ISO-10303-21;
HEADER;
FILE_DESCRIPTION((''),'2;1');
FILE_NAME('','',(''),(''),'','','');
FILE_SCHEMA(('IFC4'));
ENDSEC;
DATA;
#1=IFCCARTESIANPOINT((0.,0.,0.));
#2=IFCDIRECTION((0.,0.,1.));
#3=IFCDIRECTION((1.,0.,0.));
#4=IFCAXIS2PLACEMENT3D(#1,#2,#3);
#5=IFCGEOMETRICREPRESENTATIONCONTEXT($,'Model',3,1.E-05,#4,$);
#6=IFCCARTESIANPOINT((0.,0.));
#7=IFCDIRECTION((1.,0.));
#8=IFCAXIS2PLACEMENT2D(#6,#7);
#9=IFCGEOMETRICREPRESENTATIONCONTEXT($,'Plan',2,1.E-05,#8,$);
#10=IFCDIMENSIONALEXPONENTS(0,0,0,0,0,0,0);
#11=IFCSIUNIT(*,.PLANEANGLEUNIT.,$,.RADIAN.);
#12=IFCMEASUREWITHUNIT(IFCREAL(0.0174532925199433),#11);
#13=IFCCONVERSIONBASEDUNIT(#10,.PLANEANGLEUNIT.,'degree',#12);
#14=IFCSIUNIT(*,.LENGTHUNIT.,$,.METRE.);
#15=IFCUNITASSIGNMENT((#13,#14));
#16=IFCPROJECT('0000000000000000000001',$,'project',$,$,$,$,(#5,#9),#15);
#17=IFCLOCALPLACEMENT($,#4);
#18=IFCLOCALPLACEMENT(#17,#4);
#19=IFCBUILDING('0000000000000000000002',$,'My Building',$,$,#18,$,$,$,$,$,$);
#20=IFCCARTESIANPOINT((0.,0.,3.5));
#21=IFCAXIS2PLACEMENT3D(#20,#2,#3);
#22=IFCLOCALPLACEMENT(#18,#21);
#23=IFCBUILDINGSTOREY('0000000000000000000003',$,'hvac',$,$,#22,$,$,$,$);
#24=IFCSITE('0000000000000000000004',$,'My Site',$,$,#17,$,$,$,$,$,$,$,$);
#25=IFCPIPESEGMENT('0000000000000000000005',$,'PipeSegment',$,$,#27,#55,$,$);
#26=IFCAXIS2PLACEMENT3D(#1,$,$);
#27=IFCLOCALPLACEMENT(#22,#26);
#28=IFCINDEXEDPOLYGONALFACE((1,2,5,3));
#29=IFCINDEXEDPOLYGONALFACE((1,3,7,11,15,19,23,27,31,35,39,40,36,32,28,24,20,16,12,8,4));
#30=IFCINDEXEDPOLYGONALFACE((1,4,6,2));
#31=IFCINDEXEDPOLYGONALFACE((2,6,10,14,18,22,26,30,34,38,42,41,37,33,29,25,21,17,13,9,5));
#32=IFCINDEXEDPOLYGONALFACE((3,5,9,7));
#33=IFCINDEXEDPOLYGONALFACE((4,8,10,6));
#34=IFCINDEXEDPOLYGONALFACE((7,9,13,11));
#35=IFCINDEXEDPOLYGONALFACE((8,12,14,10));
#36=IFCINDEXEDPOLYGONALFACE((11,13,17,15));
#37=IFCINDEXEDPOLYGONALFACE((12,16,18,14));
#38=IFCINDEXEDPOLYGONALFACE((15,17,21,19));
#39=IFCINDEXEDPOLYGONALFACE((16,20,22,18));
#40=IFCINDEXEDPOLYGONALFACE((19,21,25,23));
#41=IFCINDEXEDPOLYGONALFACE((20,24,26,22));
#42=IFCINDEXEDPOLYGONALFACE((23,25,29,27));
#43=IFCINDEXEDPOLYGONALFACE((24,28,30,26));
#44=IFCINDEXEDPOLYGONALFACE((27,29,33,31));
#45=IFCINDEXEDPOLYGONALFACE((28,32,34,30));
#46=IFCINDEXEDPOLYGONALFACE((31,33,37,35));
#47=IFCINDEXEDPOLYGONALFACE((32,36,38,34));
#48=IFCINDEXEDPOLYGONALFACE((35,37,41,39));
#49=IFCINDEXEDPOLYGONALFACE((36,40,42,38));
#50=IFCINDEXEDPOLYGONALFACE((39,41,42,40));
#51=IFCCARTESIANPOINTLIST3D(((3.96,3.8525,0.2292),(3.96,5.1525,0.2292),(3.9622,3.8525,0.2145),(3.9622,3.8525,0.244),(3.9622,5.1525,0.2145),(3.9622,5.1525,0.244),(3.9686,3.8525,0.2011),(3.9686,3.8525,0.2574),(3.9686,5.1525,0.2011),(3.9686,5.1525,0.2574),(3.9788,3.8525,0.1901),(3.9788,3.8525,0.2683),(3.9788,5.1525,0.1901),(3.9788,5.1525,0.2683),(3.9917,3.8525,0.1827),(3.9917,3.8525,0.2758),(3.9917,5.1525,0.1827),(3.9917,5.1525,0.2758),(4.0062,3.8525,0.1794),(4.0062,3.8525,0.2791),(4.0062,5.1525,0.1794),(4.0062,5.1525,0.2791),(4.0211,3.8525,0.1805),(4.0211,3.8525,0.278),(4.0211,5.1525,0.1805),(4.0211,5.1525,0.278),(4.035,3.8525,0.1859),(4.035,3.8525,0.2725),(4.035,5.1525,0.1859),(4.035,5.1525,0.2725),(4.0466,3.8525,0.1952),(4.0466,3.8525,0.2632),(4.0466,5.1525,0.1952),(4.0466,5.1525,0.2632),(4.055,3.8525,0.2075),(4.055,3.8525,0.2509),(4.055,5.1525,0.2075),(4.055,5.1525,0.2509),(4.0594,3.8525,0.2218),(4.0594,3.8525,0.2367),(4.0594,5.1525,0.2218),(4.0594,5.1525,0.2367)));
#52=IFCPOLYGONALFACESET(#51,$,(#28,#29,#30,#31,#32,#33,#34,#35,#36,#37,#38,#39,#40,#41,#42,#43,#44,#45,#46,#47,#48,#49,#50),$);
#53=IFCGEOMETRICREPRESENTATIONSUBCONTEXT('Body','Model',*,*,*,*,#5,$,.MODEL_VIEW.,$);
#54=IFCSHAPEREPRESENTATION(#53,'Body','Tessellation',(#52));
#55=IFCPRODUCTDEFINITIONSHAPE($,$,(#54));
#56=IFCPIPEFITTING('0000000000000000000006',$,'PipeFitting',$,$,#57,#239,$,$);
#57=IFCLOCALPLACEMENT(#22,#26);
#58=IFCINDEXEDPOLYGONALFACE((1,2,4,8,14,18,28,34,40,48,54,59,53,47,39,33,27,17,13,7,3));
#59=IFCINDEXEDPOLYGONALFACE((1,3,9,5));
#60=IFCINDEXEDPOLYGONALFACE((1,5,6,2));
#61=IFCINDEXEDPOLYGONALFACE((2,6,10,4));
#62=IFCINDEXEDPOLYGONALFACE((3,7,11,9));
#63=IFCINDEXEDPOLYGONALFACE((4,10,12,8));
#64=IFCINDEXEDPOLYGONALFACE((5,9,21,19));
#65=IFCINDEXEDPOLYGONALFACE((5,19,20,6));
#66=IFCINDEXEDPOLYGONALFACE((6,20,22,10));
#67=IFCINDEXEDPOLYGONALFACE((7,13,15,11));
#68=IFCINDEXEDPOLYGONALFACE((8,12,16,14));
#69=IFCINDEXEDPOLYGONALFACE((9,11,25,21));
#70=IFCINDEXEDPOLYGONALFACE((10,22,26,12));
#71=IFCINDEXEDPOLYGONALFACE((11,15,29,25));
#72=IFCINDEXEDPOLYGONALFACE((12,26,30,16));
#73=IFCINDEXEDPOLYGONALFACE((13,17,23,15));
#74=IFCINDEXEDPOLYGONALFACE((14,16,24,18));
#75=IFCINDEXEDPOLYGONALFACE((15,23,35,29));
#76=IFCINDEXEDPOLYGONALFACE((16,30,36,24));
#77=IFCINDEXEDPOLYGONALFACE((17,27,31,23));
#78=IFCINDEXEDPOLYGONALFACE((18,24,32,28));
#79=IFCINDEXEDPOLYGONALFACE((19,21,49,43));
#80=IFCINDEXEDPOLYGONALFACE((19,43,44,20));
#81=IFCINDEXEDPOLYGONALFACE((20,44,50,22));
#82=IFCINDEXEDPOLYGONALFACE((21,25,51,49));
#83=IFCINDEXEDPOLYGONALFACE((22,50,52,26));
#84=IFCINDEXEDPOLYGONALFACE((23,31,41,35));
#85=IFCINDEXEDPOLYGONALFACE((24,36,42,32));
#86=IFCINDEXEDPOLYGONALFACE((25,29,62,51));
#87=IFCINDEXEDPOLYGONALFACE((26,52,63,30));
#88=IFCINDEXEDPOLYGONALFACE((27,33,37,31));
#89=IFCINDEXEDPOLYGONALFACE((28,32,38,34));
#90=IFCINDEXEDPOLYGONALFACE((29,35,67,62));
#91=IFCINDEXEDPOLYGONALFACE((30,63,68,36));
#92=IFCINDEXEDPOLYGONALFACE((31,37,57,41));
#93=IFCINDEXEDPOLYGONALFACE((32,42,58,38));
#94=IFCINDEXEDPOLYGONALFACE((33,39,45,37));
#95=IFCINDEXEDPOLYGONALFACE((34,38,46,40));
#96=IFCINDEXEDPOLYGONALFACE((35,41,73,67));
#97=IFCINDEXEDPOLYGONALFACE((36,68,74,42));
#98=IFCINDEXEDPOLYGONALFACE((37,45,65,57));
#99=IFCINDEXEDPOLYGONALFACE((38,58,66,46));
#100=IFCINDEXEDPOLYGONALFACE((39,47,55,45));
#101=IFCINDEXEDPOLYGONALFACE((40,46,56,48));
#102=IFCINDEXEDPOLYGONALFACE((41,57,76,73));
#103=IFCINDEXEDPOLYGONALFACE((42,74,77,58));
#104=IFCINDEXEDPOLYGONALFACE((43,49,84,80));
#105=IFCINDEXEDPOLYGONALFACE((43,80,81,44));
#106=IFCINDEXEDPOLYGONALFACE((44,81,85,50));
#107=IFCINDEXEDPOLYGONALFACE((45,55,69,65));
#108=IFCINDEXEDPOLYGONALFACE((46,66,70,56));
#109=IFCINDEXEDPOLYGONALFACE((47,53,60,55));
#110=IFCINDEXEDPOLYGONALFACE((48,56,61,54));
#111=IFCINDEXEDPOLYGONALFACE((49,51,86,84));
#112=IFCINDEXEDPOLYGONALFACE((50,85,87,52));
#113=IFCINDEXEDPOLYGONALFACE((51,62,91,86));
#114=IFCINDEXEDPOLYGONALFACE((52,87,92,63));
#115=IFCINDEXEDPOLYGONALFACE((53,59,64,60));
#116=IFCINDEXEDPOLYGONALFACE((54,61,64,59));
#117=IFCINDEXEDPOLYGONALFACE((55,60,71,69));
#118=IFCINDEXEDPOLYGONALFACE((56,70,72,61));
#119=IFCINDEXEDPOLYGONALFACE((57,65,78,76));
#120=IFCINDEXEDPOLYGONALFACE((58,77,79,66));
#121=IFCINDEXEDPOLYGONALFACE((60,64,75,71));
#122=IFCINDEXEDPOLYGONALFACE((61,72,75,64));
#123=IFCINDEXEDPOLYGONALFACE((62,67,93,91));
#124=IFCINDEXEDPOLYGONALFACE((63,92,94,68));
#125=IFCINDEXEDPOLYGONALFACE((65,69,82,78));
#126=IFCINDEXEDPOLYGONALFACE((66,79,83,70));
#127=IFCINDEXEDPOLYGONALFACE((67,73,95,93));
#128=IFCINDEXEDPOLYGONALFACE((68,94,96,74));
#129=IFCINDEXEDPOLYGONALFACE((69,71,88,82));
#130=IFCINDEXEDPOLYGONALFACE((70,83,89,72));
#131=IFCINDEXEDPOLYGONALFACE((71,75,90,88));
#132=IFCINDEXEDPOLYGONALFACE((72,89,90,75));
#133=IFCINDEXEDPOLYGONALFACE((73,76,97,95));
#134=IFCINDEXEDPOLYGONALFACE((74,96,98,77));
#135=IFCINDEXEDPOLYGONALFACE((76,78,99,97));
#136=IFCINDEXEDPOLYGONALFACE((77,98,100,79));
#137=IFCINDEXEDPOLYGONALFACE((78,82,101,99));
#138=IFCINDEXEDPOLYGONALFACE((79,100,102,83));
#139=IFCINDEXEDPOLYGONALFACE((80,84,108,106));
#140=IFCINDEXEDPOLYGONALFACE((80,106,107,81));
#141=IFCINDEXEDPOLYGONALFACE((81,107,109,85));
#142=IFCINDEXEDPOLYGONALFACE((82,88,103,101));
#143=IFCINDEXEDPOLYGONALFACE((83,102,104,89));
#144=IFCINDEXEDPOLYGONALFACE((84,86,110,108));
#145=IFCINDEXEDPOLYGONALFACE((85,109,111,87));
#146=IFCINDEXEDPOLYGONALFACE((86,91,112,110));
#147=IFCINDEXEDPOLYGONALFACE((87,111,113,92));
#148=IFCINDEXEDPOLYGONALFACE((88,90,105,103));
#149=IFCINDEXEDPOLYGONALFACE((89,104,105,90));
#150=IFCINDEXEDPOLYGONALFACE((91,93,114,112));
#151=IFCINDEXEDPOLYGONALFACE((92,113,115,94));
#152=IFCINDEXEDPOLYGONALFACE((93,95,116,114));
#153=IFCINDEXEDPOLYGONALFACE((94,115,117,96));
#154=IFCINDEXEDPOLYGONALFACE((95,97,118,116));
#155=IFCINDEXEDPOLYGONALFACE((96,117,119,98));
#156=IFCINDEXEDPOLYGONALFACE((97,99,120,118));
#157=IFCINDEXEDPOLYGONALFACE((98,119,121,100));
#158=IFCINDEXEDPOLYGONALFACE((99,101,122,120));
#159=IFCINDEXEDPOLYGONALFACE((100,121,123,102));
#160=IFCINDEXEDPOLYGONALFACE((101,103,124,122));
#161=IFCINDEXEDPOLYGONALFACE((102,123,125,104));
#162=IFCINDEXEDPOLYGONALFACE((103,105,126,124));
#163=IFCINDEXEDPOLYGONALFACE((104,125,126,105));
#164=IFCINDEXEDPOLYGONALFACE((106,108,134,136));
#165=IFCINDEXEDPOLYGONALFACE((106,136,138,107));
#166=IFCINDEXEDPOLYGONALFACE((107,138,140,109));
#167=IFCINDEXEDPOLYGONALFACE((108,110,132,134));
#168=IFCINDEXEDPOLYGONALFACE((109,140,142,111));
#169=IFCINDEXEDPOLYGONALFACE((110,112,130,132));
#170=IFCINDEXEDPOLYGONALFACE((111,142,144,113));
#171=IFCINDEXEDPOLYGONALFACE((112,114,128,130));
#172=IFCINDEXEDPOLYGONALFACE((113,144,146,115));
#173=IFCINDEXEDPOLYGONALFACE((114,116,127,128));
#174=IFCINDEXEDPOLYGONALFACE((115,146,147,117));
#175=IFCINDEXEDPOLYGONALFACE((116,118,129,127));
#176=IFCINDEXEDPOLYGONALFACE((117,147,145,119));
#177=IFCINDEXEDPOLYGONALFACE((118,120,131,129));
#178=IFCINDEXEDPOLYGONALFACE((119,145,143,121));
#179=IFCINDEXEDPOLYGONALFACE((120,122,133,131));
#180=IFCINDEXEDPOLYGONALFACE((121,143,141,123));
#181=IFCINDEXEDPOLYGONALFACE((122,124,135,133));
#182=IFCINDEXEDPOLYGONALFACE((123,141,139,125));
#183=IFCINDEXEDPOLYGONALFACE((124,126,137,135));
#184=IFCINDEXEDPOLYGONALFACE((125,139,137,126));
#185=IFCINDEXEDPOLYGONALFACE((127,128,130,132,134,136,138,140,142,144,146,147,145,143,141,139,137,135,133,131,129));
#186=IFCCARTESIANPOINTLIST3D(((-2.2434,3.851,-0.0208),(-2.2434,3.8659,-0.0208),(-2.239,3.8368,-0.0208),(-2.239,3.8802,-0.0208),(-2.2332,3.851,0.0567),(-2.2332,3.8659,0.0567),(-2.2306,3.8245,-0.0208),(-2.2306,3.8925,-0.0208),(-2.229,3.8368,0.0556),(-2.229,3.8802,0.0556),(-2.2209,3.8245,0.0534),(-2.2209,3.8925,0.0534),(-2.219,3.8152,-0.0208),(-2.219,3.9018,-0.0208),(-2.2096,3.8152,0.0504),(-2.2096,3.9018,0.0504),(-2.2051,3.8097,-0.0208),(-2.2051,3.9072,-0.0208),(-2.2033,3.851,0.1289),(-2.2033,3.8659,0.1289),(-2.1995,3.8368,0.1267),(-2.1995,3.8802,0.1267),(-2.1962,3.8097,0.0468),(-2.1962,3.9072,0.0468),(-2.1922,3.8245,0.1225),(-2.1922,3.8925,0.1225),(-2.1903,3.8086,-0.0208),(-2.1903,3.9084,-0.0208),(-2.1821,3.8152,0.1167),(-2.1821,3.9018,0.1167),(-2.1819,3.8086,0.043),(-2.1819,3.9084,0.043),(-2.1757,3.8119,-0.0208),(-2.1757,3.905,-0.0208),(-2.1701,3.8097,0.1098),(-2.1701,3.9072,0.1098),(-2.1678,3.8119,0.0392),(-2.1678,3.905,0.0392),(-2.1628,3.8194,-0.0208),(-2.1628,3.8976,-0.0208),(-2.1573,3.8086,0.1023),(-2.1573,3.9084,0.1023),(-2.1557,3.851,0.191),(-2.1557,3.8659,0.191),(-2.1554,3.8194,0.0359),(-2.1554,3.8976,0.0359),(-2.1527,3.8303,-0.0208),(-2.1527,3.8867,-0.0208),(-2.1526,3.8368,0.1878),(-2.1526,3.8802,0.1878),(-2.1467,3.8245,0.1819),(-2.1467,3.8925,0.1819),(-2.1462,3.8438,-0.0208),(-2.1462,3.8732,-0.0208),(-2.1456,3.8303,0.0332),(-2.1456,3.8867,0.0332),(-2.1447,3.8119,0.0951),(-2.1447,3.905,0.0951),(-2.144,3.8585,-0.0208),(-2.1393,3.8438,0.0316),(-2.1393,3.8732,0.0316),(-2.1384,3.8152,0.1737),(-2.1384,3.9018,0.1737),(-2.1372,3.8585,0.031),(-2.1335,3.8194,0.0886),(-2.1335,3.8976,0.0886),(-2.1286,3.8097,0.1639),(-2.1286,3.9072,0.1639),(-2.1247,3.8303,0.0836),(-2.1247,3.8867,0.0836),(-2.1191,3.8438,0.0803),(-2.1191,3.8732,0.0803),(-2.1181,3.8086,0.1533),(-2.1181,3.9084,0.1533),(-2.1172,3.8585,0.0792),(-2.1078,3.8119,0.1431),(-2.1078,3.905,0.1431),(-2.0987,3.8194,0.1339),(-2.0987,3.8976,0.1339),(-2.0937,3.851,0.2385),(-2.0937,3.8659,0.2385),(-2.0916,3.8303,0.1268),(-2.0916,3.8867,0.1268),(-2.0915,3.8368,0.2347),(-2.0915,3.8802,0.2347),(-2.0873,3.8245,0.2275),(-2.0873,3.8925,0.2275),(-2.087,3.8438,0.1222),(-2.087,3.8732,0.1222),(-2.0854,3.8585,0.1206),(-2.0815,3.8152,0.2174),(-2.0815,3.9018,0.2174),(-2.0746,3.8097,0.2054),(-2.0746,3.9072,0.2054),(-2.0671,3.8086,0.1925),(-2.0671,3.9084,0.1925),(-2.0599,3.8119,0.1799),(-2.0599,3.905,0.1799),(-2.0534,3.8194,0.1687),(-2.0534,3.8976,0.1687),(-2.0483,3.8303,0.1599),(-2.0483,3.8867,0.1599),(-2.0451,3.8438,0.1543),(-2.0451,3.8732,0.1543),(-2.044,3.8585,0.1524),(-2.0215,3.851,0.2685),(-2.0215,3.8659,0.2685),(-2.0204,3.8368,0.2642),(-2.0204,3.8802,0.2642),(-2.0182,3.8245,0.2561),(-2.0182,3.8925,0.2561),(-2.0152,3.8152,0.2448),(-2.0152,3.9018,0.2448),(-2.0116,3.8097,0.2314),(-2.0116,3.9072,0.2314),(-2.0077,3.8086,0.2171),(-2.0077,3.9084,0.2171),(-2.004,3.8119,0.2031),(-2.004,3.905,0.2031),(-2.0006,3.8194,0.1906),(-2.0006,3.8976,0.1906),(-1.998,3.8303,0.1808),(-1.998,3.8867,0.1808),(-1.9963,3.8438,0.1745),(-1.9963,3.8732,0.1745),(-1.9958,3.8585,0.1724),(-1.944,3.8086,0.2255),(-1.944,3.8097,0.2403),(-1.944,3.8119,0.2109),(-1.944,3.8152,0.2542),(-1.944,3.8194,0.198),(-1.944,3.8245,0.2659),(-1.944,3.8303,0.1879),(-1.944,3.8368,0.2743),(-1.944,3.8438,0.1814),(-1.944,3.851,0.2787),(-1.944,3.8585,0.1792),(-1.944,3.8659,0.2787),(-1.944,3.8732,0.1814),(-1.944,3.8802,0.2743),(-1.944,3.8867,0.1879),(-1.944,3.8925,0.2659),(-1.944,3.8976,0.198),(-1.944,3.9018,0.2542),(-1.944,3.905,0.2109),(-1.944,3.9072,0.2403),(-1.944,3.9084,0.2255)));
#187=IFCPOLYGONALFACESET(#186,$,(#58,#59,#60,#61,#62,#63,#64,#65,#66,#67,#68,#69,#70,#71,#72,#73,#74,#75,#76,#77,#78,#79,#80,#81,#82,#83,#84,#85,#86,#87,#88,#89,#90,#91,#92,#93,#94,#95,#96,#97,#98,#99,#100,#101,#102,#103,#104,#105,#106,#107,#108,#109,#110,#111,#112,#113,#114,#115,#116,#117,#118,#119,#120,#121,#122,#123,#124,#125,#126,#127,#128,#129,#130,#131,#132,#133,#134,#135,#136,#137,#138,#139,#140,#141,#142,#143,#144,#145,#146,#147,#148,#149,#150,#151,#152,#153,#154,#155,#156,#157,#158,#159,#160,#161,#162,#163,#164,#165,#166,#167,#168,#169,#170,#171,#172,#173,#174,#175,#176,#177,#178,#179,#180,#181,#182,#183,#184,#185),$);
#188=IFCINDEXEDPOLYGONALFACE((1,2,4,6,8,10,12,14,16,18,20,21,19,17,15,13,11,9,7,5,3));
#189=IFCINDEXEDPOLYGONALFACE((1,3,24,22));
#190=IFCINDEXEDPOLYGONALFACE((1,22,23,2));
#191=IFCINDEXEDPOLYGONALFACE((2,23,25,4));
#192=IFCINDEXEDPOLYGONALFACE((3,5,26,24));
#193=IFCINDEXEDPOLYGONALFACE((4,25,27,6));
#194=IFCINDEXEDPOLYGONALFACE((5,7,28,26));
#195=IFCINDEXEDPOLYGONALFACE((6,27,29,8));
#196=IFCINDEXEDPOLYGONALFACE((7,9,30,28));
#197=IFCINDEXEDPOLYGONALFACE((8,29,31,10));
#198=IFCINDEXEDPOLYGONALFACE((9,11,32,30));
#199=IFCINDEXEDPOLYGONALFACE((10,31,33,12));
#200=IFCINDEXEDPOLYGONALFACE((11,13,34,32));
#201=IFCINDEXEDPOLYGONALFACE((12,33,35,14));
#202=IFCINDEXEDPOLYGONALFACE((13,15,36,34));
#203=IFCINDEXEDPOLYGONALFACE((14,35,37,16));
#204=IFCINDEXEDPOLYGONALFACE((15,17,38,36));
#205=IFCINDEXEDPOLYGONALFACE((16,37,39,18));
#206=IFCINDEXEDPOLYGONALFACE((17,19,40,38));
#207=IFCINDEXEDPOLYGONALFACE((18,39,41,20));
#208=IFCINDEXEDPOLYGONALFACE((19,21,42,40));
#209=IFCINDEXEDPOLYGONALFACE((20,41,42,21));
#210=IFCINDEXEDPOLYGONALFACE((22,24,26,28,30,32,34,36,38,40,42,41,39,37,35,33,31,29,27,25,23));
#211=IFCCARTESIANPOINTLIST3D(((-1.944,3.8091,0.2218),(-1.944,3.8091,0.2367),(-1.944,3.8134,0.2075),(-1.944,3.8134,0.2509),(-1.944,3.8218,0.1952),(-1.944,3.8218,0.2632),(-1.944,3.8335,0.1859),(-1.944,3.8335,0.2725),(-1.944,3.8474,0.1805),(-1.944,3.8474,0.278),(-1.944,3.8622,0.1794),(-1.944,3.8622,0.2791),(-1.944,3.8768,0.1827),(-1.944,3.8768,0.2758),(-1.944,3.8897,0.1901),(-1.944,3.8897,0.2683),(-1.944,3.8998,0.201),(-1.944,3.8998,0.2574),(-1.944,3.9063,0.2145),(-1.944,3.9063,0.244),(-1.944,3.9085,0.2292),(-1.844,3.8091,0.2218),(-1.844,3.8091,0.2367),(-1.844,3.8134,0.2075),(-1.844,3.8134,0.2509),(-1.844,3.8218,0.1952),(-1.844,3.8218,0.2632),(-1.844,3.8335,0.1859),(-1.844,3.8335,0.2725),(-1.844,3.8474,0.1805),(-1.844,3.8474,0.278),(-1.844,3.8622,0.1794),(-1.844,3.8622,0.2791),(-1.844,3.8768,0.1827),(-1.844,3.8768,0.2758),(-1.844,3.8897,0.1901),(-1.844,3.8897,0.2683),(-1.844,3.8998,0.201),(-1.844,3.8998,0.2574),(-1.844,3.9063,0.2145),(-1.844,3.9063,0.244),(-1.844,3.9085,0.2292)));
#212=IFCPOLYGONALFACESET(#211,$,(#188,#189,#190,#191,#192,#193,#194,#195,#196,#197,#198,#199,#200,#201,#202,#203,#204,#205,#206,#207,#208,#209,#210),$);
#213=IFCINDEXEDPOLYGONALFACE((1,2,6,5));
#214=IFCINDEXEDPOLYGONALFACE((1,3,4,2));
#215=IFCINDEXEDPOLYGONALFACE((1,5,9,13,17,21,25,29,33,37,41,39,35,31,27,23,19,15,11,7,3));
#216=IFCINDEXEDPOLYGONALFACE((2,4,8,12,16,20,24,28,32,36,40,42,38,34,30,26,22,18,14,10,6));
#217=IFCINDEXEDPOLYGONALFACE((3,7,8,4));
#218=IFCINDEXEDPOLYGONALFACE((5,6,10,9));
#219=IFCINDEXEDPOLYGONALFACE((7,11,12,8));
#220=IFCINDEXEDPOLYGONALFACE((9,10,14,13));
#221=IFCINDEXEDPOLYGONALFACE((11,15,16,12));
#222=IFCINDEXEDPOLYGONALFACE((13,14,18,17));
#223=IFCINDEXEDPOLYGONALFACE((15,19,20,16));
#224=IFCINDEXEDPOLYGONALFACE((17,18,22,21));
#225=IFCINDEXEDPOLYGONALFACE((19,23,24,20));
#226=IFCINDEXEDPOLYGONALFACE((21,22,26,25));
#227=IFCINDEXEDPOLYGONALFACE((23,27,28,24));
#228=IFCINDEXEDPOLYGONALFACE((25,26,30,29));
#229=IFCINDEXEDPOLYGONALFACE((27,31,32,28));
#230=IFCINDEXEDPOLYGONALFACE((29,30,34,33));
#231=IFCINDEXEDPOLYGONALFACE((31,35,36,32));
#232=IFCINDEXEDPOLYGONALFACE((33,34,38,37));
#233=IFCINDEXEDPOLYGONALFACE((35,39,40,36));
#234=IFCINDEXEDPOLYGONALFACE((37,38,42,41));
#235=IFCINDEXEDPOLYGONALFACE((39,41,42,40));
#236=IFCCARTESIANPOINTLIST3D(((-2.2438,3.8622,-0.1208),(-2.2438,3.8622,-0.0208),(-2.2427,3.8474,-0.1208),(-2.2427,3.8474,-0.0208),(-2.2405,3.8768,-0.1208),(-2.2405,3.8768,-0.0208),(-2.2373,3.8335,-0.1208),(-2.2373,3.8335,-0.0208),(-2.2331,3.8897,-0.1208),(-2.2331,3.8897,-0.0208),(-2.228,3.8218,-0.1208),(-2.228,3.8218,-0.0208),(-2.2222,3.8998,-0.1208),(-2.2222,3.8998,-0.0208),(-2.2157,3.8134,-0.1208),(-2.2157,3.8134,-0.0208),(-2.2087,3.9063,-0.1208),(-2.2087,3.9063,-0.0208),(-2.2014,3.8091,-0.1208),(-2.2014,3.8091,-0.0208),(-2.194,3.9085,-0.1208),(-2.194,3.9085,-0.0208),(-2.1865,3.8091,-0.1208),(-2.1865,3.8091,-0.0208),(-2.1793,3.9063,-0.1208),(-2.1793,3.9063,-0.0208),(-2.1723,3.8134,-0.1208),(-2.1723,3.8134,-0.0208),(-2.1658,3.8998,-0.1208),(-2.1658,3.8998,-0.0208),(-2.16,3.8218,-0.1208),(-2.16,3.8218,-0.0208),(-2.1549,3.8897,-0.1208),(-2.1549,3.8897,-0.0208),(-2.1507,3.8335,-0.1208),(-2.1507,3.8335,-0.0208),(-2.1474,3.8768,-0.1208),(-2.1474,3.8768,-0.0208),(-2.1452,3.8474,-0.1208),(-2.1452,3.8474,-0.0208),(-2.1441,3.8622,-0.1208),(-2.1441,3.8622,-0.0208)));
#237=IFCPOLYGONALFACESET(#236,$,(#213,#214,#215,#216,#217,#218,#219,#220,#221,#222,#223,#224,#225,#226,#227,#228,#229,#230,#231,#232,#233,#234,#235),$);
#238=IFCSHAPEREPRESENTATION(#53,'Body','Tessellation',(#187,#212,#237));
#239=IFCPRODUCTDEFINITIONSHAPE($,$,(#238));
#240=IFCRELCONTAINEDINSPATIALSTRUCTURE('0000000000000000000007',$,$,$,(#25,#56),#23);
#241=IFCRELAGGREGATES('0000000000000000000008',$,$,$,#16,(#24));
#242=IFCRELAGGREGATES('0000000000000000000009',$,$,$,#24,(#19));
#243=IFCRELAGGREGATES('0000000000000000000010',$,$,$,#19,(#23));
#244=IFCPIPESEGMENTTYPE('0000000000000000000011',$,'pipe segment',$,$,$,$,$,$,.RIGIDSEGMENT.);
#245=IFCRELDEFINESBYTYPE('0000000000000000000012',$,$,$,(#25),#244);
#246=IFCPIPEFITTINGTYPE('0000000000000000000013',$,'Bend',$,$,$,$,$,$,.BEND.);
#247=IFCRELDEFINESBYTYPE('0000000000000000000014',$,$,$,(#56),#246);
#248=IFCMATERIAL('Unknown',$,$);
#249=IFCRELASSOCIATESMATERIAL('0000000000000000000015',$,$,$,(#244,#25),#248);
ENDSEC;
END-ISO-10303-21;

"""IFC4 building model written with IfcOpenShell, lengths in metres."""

from ifc_helpers import new_model, entity, si_unit, converted_unit, frame, origin_with_axes, origin_2d_with_axis, place, context, subcontext, project, spatial, circle, extrude, source, transform, mapped, material, material_profile, profile_set, profile_usage, type_object, type_shapes, element, save


model = new_model("IFC4")

# Units and contexts
model_context = context("Model", 3, precision=1e-05, world=origin_with_axes())
plan_context = context("Plan", 2, precision=1e-05, world=origin_2d_with_axis())
body_context_1 = subcontext(model_context, "Body", "Model", "MODEL_VIEW")
ifc_project = project(units=[converted_unit("PLANEANGLEUNIT", "degree", entity("IfcReal", 0.0174532925199433), si_unit("PLANEANGLEUNIT", "RADIAN"), dimensions=[0, 0, 0, 0, 0, 0, 0]), si_unit("LENGTHUNIT", "METRE")], contexts=[model_context, plan_context])

# Site, building, storey
site_placement = place(None, origin_with_axes())
site = spatial("IfcSite", under=ifc_project, at=site_placement, Name="My Site")
building_placement = place(site_placement, origin_with_axes())
building = spatial("IfcBuilding", under=site, at=building_placement, Name="My Building")
storey_placement = place(building_placement, frame((0.0, 0.0, 3.5), z_axis=(0.0, 0.0, 1.0), x_axis=(1.0, 0.0, 0.0)))
storey = spatial("IfcBuildingStorey", under=building, at=storey_placement, Name="hvac")

# Shared definitions
ifc_material = material(Name="Unknown")

# Pipe segment
ifc_material_profile_1 = material_profile(ifc_material, circle(Radius=0.05))
ifc_profile_set_1 = profile_set([ifc_material_profile_1])
pipe_segment_type = type_object("IfcPipeSegmentType", Name="pipe segment", PredefinedType="RIGIDSEGMENT", material=ifc_profile_set_1)
ifc_profile_usage_1 = profile_usage(ifc_profile_set_1, cardinal=5)
pipe_segment_1_placement = place(storey_placement, frame((4.01, 3.8525, 0.2292), z_axis=(0.0, 1.0, 0.0), x_axis=(-1.0, 0.0, 0.0)))
element("IfcPipeSegment", 1, at=pipe_segment_1_placement, inside=storey, type_object=pipe_segment_type, material=ifc_profile_usage_1, Name="PipeSegment", context=body_context_1, shape_type="SweptSolid", body=[
    extrude(circle(Radius=0.05), origin_with_axes(), (0.0, 0.0, 1.0), 1.3),
])

# Pipe fitting
pipe_fitting_type = type_object("IfcPipeFittingType", Name="Bend", PredefinedType="BEND")
shared_shape_1 = source(origin_with_axes(), body_context_1, "Body", "SolidModel", [
    entity("IfcSweptDiskSolid", entity("IfcIndexedPolyCurve", entity("IfcCartesianPointList3D", [[0.0, 0.0, -0.1], [0.0, -0.0732, -0.2768], [0.0, -0.25, -0.35]]), [entity("IfcArcIndex", [1, 2, 3])]), 0.05),
    extrude(circle(Radius=0.05), origin_with_axes(), (0.0, 0.0, -1.0), 0.1),
    extrude(circle(Radius=0.05), frame((0.0, -0.25, -0.35), z_axis=(0.0, -1.0, -0.000001), x_axis=(1.0, 0.0, 0.0)), (0.0, 0.0, 1.0), 0.1),
])
type_shapes(pipe_fitting_type, [shared_shape_1])
pipe_fitting_placement = place(storey_placement, frame((-1.844, 3.8585, 0.2292), z_axis=(1.0, 0.0, 0.0), x_axis=(0.0, 1.0, 0.0)))
element("IfcPipeFitting", 2, at=pipe_fitting_placement, inside=storey, type_object=pipe_fitting_type, Name="PipeFitting", context=body_context_1, shape_type="MappedRepresentation", body=[
    mapped(shared_shape_1, transform((0.0, 0.0, 0.0), x_axis=(1.0, 0.0, 0.0), y_axis=(0.0, 1.0, 0.0), z_axis=(0.0, 0.0, 1.0), scale=1.0)),
])

save(model, "model.ifc")
